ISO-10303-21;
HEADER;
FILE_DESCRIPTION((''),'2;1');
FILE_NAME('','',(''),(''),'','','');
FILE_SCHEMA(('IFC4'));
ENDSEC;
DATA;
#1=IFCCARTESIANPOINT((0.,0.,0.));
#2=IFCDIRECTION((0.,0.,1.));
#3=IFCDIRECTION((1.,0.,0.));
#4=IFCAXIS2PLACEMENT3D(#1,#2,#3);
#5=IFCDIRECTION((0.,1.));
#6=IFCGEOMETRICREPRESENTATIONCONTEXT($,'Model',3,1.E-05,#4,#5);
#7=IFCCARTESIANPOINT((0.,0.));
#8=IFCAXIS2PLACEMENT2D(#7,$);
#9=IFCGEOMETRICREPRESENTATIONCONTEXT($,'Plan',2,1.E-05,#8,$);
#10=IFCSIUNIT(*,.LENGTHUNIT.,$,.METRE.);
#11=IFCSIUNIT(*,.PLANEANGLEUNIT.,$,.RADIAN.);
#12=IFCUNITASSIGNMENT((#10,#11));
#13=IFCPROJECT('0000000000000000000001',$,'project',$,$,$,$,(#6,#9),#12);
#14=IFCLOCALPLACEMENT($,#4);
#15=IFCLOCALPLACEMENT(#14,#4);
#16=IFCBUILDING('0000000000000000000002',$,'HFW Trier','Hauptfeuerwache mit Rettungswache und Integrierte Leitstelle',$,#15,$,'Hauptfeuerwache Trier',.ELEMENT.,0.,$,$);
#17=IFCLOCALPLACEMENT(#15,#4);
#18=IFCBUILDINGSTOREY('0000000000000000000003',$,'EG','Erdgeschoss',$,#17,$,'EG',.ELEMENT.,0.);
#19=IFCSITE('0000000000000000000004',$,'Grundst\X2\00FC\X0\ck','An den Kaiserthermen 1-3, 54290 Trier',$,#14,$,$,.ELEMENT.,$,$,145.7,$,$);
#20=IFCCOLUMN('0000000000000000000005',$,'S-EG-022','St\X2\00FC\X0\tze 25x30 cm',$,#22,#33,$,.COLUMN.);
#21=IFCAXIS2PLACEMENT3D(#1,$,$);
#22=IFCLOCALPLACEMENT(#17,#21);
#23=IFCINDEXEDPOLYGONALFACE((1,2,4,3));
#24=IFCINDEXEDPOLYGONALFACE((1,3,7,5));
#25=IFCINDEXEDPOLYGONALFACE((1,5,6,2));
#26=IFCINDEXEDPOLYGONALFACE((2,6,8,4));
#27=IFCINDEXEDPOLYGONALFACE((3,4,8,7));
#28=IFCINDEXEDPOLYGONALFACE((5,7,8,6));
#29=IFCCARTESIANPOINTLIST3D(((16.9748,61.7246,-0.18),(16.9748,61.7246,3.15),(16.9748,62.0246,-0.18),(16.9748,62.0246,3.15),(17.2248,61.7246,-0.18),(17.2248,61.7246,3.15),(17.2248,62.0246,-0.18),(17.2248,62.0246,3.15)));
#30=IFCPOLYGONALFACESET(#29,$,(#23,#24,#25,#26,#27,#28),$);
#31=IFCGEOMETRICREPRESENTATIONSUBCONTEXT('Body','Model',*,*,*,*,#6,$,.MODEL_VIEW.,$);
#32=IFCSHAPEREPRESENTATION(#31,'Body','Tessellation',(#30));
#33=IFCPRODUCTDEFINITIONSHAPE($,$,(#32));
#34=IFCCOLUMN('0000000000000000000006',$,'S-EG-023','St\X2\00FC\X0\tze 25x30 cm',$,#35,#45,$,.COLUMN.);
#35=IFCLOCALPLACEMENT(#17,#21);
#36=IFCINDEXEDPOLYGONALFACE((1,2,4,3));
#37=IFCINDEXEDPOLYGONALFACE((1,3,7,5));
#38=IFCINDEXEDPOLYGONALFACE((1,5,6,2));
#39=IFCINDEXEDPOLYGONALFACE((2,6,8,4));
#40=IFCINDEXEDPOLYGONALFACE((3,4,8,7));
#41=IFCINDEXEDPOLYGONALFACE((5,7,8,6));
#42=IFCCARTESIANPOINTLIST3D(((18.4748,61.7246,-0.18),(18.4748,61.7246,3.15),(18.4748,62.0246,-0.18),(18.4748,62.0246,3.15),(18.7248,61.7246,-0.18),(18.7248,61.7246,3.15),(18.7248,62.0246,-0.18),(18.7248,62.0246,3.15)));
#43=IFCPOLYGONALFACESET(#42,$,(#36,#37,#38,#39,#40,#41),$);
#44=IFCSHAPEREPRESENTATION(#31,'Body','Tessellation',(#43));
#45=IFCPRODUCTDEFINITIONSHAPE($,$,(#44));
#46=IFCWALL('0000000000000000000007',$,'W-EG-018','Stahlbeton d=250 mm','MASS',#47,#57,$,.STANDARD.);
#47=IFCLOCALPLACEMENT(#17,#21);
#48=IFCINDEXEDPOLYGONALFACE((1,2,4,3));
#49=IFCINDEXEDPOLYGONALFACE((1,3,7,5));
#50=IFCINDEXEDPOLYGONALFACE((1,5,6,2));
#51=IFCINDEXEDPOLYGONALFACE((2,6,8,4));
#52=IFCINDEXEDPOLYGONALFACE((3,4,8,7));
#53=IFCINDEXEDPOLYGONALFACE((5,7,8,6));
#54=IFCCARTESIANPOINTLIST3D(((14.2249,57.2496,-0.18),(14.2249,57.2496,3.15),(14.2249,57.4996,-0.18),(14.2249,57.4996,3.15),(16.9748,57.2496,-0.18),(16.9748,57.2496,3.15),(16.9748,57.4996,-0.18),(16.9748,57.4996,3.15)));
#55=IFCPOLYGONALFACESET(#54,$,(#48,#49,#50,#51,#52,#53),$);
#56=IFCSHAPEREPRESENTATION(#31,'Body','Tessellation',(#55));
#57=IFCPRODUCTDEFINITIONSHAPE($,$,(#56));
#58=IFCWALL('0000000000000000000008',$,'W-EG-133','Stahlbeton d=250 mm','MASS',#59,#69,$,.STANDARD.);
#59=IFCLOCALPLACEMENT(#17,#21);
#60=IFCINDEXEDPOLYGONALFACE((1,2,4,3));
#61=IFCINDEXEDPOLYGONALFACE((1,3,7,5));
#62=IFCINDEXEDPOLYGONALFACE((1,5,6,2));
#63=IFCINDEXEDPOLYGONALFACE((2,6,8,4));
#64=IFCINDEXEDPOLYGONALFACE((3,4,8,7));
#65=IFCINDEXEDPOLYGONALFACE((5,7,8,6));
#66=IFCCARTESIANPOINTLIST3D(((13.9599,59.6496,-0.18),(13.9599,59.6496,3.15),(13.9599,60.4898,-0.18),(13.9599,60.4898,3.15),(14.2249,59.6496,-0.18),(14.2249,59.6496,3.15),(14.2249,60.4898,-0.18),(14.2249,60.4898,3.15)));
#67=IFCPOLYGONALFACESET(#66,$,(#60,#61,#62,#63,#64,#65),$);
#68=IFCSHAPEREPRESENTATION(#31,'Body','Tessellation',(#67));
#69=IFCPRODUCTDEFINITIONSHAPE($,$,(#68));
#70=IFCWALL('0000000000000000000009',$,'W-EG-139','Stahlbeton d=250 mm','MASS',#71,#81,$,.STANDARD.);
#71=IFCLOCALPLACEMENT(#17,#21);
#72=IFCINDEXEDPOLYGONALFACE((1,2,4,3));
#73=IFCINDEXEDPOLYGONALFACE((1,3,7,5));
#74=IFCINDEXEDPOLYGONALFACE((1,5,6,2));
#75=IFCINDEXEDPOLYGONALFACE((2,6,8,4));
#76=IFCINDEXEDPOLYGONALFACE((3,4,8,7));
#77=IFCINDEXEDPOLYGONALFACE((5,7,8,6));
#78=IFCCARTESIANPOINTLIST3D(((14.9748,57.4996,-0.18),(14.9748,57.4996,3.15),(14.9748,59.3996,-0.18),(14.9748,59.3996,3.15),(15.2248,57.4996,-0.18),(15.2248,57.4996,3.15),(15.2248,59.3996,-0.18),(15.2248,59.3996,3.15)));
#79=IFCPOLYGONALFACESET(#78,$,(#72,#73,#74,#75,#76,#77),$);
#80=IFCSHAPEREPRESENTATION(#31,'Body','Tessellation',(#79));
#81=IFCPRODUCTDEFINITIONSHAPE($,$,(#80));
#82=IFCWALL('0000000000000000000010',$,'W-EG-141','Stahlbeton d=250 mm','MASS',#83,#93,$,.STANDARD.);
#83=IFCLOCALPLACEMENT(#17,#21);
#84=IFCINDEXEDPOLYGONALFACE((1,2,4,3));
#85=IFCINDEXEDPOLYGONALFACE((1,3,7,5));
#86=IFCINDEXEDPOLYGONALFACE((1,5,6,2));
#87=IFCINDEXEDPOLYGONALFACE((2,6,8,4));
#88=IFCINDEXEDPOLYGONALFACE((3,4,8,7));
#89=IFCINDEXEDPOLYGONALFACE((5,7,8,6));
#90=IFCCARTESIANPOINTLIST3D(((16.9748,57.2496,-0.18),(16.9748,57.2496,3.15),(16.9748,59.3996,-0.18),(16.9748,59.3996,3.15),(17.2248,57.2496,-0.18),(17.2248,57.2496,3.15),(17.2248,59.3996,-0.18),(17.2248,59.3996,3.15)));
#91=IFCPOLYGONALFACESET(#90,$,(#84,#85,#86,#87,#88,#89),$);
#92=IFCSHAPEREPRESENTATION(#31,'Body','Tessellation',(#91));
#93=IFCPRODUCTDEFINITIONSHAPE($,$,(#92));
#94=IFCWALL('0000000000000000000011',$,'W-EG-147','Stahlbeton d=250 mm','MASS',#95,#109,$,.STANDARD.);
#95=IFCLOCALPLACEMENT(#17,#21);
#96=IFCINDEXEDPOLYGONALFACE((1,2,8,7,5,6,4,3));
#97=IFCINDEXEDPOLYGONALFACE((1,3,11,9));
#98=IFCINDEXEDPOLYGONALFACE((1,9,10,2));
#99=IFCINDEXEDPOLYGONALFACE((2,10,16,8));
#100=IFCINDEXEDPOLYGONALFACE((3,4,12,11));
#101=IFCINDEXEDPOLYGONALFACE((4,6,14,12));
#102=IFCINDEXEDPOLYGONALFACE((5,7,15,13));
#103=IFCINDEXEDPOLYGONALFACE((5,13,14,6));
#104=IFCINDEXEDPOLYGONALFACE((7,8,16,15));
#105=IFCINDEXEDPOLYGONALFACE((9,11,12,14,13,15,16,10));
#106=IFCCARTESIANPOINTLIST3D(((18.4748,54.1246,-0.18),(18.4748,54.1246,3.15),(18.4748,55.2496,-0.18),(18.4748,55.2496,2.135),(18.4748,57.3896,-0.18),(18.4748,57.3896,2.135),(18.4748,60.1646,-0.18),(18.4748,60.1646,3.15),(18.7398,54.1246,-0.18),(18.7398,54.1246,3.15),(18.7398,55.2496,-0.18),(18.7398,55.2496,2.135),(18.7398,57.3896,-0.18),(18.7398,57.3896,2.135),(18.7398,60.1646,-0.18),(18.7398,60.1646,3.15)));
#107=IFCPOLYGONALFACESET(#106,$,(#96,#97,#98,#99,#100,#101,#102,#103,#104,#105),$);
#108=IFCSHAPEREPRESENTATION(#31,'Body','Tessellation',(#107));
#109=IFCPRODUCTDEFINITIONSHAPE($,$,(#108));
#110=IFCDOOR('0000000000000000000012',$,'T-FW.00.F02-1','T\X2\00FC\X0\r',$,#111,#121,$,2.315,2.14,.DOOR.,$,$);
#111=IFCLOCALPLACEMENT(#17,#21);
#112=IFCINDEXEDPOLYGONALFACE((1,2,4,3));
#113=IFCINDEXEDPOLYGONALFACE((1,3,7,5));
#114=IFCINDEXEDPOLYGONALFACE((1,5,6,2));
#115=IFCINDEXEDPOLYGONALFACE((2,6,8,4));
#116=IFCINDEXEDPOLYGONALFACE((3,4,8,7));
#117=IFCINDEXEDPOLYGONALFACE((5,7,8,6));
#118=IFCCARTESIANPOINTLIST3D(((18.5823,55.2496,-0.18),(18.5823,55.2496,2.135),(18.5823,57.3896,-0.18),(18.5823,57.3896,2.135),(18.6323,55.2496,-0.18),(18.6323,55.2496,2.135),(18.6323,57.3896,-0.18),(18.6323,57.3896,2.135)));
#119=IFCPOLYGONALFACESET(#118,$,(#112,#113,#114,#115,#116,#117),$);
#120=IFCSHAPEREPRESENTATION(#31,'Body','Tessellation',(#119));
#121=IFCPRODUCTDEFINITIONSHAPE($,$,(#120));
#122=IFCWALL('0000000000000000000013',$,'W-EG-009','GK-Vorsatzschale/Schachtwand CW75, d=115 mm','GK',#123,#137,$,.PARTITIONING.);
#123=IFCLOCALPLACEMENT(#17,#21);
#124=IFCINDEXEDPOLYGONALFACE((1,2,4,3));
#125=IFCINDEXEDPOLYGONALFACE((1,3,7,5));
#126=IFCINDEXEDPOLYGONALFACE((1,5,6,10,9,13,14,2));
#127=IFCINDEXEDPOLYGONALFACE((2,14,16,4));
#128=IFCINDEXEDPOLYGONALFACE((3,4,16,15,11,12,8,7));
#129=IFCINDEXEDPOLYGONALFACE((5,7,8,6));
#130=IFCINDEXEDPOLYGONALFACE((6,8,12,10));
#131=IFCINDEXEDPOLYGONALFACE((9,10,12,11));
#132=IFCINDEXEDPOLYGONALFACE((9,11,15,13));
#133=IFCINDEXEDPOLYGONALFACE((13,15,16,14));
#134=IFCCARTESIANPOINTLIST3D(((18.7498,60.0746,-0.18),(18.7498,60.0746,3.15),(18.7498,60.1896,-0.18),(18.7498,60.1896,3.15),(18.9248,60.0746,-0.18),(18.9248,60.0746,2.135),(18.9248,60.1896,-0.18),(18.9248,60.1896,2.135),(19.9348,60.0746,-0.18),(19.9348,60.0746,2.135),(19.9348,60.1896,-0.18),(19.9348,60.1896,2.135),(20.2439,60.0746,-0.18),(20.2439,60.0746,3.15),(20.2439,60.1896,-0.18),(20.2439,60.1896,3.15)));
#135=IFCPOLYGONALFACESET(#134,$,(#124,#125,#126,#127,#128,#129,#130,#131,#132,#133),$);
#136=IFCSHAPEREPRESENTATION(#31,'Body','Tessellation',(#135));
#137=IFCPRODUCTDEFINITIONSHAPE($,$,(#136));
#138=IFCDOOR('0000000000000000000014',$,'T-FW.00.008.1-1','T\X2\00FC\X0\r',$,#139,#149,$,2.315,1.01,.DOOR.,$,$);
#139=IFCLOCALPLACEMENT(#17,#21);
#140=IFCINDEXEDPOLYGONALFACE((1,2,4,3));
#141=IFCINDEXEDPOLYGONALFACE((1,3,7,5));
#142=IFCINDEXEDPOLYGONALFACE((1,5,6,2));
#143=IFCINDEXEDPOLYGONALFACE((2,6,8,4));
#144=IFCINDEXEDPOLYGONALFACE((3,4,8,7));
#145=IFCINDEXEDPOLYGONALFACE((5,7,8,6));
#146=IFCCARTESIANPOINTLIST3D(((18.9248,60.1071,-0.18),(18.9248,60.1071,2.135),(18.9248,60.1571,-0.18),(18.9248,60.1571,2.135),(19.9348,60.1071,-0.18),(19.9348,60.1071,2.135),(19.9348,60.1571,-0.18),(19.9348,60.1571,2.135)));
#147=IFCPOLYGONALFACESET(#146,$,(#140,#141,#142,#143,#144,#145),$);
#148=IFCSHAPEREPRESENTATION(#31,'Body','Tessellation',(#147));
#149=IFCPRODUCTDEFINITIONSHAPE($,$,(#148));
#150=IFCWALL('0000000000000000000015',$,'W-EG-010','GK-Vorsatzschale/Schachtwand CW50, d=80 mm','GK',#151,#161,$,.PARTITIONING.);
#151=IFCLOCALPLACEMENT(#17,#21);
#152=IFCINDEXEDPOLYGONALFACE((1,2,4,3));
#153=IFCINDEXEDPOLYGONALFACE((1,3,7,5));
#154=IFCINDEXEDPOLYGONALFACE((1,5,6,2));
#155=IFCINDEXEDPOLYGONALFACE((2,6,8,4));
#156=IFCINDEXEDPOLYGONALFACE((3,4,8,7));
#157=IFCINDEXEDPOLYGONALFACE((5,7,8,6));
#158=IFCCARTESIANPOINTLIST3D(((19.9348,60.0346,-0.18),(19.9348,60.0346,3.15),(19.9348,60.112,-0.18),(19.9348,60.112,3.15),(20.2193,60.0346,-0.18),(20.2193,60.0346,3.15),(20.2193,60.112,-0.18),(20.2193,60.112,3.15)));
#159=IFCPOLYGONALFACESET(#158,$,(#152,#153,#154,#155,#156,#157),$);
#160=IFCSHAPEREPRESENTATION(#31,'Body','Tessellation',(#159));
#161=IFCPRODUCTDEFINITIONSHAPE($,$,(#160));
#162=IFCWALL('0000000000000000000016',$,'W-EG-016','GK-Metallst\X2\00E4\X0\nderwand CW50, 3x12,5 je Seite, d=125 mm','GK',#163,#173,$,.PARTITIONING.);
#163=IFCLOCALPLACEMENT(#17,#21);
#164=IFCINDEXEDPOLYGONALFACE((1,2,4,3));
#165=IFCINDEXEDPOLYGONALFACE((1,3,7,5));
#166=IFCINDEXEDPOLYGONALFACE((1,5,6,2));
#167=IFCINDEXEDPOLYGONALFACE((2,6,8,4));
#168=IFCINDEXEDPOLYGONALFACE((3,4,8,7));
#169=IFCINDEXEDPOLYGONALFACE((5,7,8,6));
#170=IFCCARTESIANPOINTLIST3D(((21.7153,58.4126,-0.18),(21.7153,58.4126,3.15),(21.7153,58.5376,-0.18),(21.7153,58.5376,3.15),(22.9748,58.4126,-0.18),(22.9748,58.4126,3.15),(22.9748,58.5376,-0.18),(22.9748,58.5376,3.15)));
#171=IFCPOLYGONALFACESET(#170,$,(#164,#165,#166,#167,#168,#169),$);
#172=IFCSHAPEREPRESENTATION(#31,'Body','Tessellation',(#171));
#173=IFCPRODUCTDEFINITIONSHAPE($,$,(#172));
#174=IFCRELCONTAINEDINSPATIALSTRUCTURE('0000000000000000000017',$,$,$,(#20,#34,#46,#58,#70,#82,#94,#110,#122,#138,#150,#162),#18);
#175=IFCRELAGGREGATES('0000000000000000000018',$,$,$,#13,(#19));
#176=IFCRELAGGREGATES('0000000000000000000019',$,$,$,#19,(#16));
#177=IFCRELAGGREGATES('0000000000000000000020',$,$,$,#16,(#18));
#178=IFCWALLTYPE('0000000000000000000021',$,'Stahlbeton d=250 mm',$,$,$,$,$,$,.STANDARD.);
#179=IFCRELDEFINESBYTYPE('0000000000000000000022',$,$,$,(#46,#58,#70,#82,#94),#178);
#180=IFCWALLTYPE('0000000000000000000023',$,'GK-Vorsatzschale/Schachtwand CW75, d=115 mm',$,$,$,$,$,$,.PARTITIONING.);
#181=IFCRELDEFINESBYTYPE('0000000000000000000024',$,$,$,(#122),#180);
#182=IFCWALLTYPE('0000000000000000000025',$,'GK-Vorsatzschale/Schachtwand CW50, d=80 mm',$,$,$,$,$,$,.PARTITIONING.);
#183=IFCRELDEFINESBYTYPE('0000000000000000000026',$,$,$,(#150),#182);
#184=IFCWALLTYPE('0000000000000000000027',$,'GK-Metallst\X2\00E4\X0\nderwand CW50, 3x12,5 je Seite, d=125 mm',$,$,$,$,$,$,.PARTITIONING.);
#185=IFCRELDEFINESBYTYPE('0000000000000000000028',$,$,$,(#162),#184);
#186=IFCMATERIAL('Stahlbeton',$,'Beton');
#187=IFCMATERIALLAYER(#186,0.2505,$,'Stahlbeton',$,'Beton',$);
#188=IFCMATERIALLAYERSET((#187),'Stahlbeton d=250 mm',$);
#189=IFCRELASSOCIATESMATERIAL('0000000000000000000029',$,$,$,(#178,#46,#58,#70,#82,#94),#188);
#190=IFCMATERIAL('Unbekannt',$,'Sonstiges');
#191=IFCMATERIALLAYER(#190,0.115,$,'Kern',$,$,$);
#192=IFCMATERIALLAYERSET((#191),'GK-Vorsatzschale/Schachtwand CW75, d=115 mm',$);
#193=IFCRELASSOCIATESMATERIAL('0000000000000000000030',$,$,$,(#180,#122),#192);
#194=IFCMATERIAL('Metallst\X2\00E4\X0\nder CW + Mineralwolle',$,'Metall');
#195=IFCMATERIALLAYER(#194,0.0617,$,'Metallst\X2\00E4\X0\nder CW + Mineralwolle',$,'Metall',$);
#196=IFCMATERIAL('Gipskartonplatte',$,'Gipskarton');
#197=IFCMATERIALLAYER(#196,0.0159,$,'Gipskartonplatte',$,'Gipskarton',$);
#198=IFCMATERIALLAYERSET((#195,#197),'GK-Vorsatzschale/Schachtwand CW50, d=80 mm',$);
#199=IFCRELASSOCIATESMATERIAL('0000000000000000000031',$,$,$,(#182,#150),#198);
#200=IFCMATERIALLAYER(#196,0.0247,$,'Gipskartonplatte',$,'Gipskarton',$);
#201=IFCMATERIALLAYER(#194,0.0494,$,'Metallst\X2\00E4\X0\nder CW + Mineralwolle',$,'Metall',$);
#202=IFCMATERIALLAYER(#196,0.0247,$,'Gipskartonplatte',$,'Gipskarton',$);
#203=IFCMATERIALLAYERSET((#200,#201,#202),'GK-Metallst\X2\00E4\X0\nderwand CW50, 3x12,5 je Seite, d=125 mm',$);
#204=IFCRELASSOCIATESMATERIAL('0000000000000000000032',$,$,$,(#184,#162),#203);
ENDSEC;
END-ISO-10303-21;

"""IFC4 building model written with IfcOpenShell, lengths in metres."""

from ifc_helpers import new_model, si_unit, direction, frame, frame_2d, origin_with_axes, origin_2d, place, context, subcontext, project, spatial, rectangle, extrude, material, layer, layer_set, layer_usage, type_object, element, fill, save


model = new_model("IFC4")

# Units and contexts
model_context = context("Model", 3, precision=1e-05, world=origin_with_axes(), true_north=direction((0.0, 1.0)))
plan_context = context("Plan", 2, precision=1e-05, world=origin_2d())
body_context = subcontext(model_context, "Body", "Model", "MODEL_VIEW")
ifc_project = project(units=[si_unit("LENGTHUNIT", "METRE"), si_unit("PLANEANGLEUNIT", "RADIAN")], contexts=[model_context, plan_context])

# Site, building, storey
site_placement = place(None, origin_with_axes())
site = spatial("IfcSite", under=ifc_project, at=site_placement, Name="Grundstück", Description="An den Kaiserthermen 1-3, 54290 Trier", CompositionType="ELEMENT", RefElevation=145.7)
building_placement = place(site_placement, origin_with_axes())
building = spatial("IfcBuilding", under=site, at=building_placement, Name="HFW Trier", Description="Hauptfeuerwache mit Rettungswache und Integrierte Leitstelle", LongName="Hauptfeuerwache Trier", CompositionType="ELEMENT", ElevationOfRefHeight=0.0)
storey_placement = place(building_placement, origin_with_axes())
storey = spatial("IfcBuildingStorey", under=building, at=storey_placement, Name="EG", Description="Erdgeschoss", LongName="EG", CompositionType="ELEMENT", Elevation=0.0)

# Columns
for number, where, z_axis, x_axis, name in (
    (1, (16.9748, 61.8746, -0.18), (0.0, 0.0, 1.0), (1.0, 0.0, 0.0), "S-EG-022"),
    (2, (18.4748, 61.8746, -0.18), (0.0, 0.0, 1.0), (1.0, 0.0, 0.0), "S-EG-023"),
):
    element("IfcColumn", number, at=place(storey_placement, frame(where, z_axis=z_axis, x_axis=x_axis)), inside=storey, Name=name, Description="Stütze 25x30 cm", PredefinedType="COLUMN", context=body_context, shape_type="SweptSolid", body=[
        extrude(rectangle(XDim=0.25, YDim=0.3, at=frame_2d((0.125, 0.0))), origin_with_axes(), (0.0, 0.0, 1.0), 3.33),
    ])

# Walls
ifc_material_1 = material(Name="Stahlbeton", Category="Beton")
ifc_layer_1 = layer(ifc_material_1, 0.2505, Name="Stahlbeton", Category="Beton")
ifc_layer_set_1 = layer_set([ifc_layer_1], Name="Stahlbeton d=250 mm")
ifc_layer_usage_1 = layer_usage(ifc_layer_set_1, "AXIS2", "POSITIVE", -0.125)
wall_type_1 = type_object("IfcWallType", Name="Stahlbeton d=250 mm", PredefinedType="STANDARD", material=ifc_layer_set_1)
wall_1_placement = place(storey_placement, frame((14.2249, 57.3746, -0.18), z_axis=(0.0, 0.0, 1.0), x_axis=(1.0, 0.0, 0.0)))
element("IfcWall", 3, at=wall_1_placement, inside=storey, type_object=wall_type_1, material=ifc_layer_usage_1, Name="W-EG-018", Description="Stahlbeton d=250 mm", ObjectType="MASS", PredefinedType="STANDARD", context=body_context, shape_type="SweptSolid", body=[
    extrude(rectangle(XDim=2.7499, YDim=0.25, at=frame_2d((1.3749, 0.0))), origin_with_axes(), (0.0, 0.0, 1.0), 3.33),
])
ifc_layer_usage_2 = layer_usage(ifc_layer_set_1, "AXIS2", "POSITIVE", -0.1325)
wall_2_placement = place(storey_placement, frame((14.0924, 60.4898, -0.18), z_axis=(0.0, 0.0, 1.0), x_axis=(0.0, -1.0, 0.0)))
element("IfcWall", 4, at=wall_2_placement, inside=storey, type_object=wall_type_1, material=ifc_layer_usage_2, Name="W-EG-133", Description="Stahlbeton d=250 mm", ObjectType="MASS", PredefinedType="STANDARD", context=body_context, shape_type="SweptSolid", body=[
    extrude(rectangle(XDim=0.8402, YDim=0.265, at=frame_2d((0.4201, 0.0))), origin_with_axes(), (0.0, 0.0, 1.0), 3.33),
])
ifc_layer_usage_3 = layer_usage(ifc_layer_set_1, "AXIS2", "POSITIVE", -0.125)
wall_3_placement = place(storey_placement, frame((15.0998, 59.3996, -0.18), z_axis=(0.0, 0.0, 1.0), x_axis=(0.0, -1.0, 0.0)))
element("IfcWall", 5, at=wall_3_placement, inside=storey, type_object=wall_type_1, material=ifc_layer_usage_3, Name="W-EG-139", Description="Stahlbeton d=250 mm", ObjectType="MASS", PredefinedType="STANDARD", context=body_context, shape_type="SweptSolid", body=[
    extrude(rectangle(XDim=1.9, YDim=0.25, at=frame_2d((0.95, 0.0))), origin_with_axes(), (0.0, 0.0, 1.0), 3.33),
])
ifc_layer_usage_4 = layer_usage(ifc_layer_set_1, "AXIS2", "POSITIVE", -0.125)
wall_4_placement = place(storey_placement, frame((17.0998, 59.3996, -0.18), z_axis=(0.0, 0.0, 1.0), x_axis=(0.0, -1.0, 0.0)))
element("IfcWall", 6, at=wall_4_placement, inside=storey, type_object=wall_type_1, material=ifc_layer_usage_4, Name="W-EG-141", Description="Stahlbeton d=250 mm", ObjectType="MASS", PredefinedType="STANDARD", context=body_context, shape_type="SweptSolid", body=[
    extrude(rectangle(XDim=2.15, YDim=0.25, at=frame_2d((1.075, 0.0))), origin_with_axes(), (0.0, 0.0, 1.0), 3.33),
])

# Walls, openings, doors
ifc_layer_usage_5 = layer_usage(ifc_layer_set_1, "AXIS2", "POSITIVE", -0.1325)
wall_5_placement = place(storey_placement, frame((18.6073, 60.1646, -0.18), z_axis=(0.0, 0.0, 1.0), x_axis=(0.0, -1.0, 0.0)))
wall_5 = element("IfcWall", 7, at=wall_5_placement, inside=storey, type_object=wall_type_1, material=ifc_layer_usage_5, Name="W-EG-147", Description="Stahlbeton d=250 mm", ObjectType="MASS", PredefinedType="STANDARD", context=body_context, shape_type="SweptSolid", body=[
    extrude(rectangle(XDim=6.04, YDim=0.265, at=frame_2d((3.02, 0.0))), origin_with_axes(), (0.0, 0.0, 1.0), 3.33),
])
opening_1_placement = place(wall_5_placement, frame((2.775, 0.0, 0.0), z_axis=(0.0, 0.0, 1.0), x_axis=(1.0, 0.0, 0.0)))
opening_1 = element("IfcOpeningElement", 8, at=opening_1_placement, cuts=wall_5, PredefinedType="OPENING", context=body_context, shape_type="SweptSolid", body=[
    extrude(rectangle(XDim=2.14, YDim=0.365, at=frame_2d((1.07, 0.0))), origin_with_axes(), (0.0, 0.0, 1.0), 2.315),
])
door_1_placement = place(wall_5_placement, frame((2.775, 0.0, 0.0), z_axis=(0.0, 0.0, 1.0), x_axis=(1.0, 0.0, 0.0)))
door_1 = element("IfcDoor", 9, at=door_1_placement, inside=storey, Name="T-FW.00.F02-1", Description="Tür", OverallHeight=2.315, OverallWidth=2.14, PredefinedType="DOOR", context=body_context, shape_type="SweptSolid", body=[
    extrude(rectangle(XDim=2.14, YDim=0.05, at=frame_2d((1.07, 0.0))), origin_with_axes(), (0.0, 0.0, 1.0), 2.315),
])
fill(opening_1, door_1)
ifc_material_2 = material(Name="Unbekannt", Category="Sonstiges")
ifc_layer_2 = layer(ifc_material_2, 0.115, Name="Kern")
ifc_layer_set_2 = layer_set([ifc_layer_2], Name="GK-Vorsatzschale/Schachtwand CW75, d=115 mm")
ifc_layer_usage_6 = layer_usage(ifc_layer_set_2, "AXIS2", "POSITIVE", -0.0575)
wall_type_2 = type_object("IfcWallType", Name="GK-Vorsatzschale/Schachtwand CW75, d=115 mm", PredefinedType="PARTITIONING", material=ifc_layer_set_2)
wall_6_placement = place(storey_placement, frame((18.7498, 60.1321, -0.18), z_axis=(0.0, 0.0, 1.0), x_axis=(1.0, 0.0, 0.0)))
wall_6 = element("IfcWall", 10, at=wall_6_placement, inside=storey, type_object=wall_type_2, material=ifc_layer_usage_6, Name="W-EG-009", Description="GK-Vorsatzschale/Schachtwand CW75, d=115 mm", ObjectType="GK", PredefinedType="PARTITIONING", context=body_context, shape_type="SweptSolid", body=[
    extrude(rectangle(XDim=1.4941, YDim=0.115, at=frame_2d((0.747, 0.0))), origin_with_axes(), (0.0, 0.0, 1.0), 3.33),
])
opening_2_placement = place(wall_6_placement, frame((0.175, 0.0, 0.0), z_axis=(0.0, 0.0, 1.0), x_axis=(1.0, 0.0, 0.0)))
opening_2 = element("IfcOpeningElement", 11, at=opening_2_placement, cuts=wall_6, PredefinedType="OPENING", context=body_context, shape_type="SweptSolid", body=[
    extrude(rectangle(XDim=1.01, YDim=0.215, at=frame_2d((0.505, 0.0))), origin_with_axes(), (0.0, 0.0, 1.0), 2.315),
])
door_2_placement = place(wall_6_placement, frame((0.175, 0.0, 0.0), z_axis=(0.0, 0.0, 1.0), x_axis=(1.0, 0.0, 0.0)))
door_2 = element("IfcDoor", 12, at=door_2_placement, inside=storey, Name="T-FW.00.008.1-1", Description="Tür", OverallHeight=2.315, OverallWidth=1.01, PredefinedType="DOOR", context=body_context, shape_type="SweptSolid", body=[
    extrude(rectangle(XDim=1.01, YDim=0.05, at=frame_2d((0.505, 0.0))), origin_with_axes(), (0.0, 0.0, 1.0), 2.315),
])
fill(opening_2, door_2)

# Walls
ifc_material_3 = material(Name="Metallständer CW + Mineralwolle", Category="Metall")
ifc_layer_3 = layer(ifc_material_3, 0.0617, Name="Metallständer CW + Mineralwolle", Category="Metall")
ifc_material_4 = material(Name="Gipskartonplatte", Category="Gipskarton")
ifc_layer_4 = layer(ifc_material_4, 0.0159, Name="Gipskartonplatte", Category="Gipskarton")
ifc_layer_set_3 = layer_set([ifc_layer_3, ifc_layer_4], Name="GK-Vorsatzschale/Schachtwand CW50, d=80 mm")
ifc_layer_usage_7 = layer_usage(ifc_layer_set_3, "AXIS2", "POSITIVE", -0.0387)
wall_type_3 = type_object("IfcWallType", Name="GK-Vorsatzschale/Schachtwand CW50, d=80 mm", PredefinedType="PARTITIONING", material=ifc_layer_set_3)
wall_7_placement = place(storey_placement, frame((19.9348, 60.0733, -0.18), z_axis=(0.0, 0.0, 1.0), x_axis=(1.0, 0.0, 0.0)))
element("IfcWall", 13, at=wall_7_placement, inside=storey, type_object=wall_type_3, material=ifc_layer_usage_7, Name="W-EG-010", Description="GK-Vorsatzschale/Schachtwand CW50, d=80 mm", ObjectType="GK", PredefinedType="PARTITIONING", context=body_context, shape_type="SweptSolid", body=[
    extrude(rectangle(XDim=0.2845, YDim=0.0775, at=frame_2d((0.1423, 0.0))), origin_with_axes(), (0.0, 0.0, 1.0), 3.33),
])
ifc_layer_5 = layer(ifc_material_4, 0.0247, Name="Gipskartonplatte", Category="Gipskarton")
ifc_layer_6 = layer(ifc_material_3, 0.0494, Name="Metallständer CW + Mineralwolle", Category="Metall")
ifc_layer_7 = layer(ifc_material_4, 0.0247, Name="Gipskartonplatte", Category="Gipskarton")
ifc_layer_set_4 = layer_set([ifc_layer_5, ifc_layer_6, ifc_layer_7], Name="GK-Metallständerwand CW50, 3x12,5 je Seite, d=125 mm")
ifc_layer_usage_8 = layer_usage(ifc_layer_set_4, "AXIS2", "POSITIVE", -0.0625)
wall_type_4 = type_object("IfcWallType", Name="GK-Metallständerwand CW50, 3x12,5 je Seite, d=125 mm", PredefinedType="PARTITIONING", material=ifc_layer_set_4)
wall_8_placement = place(storey_placement, frame((21.7153, 58.4751, -0.18), z_axis=(0.0, 0.0, 1.0), x_axis=(1.0, 0.0, 0.0)))
element("IfcWall", 14, at=wall_8_placement, inside=storey, type_object=wall_type_4, material=ifc_layer_usage_8, Name="W-EG-016", Description="GK-Metallständerwand CW50, 3x12,5 je Seite, d=125 mm", ObjectType="GK", PredefinedType="PARTITIONING", context=body_context, shape_type="SweptSolid", body=[
    extrude(rectangle(XDim=1.2595, YDim=0.1251, at=frame_2d((0.6297, 0.0))), origin_with_axes(), (0.0, 0.0, 1.0), 3.33),
])

save(model, "model.ifc")
